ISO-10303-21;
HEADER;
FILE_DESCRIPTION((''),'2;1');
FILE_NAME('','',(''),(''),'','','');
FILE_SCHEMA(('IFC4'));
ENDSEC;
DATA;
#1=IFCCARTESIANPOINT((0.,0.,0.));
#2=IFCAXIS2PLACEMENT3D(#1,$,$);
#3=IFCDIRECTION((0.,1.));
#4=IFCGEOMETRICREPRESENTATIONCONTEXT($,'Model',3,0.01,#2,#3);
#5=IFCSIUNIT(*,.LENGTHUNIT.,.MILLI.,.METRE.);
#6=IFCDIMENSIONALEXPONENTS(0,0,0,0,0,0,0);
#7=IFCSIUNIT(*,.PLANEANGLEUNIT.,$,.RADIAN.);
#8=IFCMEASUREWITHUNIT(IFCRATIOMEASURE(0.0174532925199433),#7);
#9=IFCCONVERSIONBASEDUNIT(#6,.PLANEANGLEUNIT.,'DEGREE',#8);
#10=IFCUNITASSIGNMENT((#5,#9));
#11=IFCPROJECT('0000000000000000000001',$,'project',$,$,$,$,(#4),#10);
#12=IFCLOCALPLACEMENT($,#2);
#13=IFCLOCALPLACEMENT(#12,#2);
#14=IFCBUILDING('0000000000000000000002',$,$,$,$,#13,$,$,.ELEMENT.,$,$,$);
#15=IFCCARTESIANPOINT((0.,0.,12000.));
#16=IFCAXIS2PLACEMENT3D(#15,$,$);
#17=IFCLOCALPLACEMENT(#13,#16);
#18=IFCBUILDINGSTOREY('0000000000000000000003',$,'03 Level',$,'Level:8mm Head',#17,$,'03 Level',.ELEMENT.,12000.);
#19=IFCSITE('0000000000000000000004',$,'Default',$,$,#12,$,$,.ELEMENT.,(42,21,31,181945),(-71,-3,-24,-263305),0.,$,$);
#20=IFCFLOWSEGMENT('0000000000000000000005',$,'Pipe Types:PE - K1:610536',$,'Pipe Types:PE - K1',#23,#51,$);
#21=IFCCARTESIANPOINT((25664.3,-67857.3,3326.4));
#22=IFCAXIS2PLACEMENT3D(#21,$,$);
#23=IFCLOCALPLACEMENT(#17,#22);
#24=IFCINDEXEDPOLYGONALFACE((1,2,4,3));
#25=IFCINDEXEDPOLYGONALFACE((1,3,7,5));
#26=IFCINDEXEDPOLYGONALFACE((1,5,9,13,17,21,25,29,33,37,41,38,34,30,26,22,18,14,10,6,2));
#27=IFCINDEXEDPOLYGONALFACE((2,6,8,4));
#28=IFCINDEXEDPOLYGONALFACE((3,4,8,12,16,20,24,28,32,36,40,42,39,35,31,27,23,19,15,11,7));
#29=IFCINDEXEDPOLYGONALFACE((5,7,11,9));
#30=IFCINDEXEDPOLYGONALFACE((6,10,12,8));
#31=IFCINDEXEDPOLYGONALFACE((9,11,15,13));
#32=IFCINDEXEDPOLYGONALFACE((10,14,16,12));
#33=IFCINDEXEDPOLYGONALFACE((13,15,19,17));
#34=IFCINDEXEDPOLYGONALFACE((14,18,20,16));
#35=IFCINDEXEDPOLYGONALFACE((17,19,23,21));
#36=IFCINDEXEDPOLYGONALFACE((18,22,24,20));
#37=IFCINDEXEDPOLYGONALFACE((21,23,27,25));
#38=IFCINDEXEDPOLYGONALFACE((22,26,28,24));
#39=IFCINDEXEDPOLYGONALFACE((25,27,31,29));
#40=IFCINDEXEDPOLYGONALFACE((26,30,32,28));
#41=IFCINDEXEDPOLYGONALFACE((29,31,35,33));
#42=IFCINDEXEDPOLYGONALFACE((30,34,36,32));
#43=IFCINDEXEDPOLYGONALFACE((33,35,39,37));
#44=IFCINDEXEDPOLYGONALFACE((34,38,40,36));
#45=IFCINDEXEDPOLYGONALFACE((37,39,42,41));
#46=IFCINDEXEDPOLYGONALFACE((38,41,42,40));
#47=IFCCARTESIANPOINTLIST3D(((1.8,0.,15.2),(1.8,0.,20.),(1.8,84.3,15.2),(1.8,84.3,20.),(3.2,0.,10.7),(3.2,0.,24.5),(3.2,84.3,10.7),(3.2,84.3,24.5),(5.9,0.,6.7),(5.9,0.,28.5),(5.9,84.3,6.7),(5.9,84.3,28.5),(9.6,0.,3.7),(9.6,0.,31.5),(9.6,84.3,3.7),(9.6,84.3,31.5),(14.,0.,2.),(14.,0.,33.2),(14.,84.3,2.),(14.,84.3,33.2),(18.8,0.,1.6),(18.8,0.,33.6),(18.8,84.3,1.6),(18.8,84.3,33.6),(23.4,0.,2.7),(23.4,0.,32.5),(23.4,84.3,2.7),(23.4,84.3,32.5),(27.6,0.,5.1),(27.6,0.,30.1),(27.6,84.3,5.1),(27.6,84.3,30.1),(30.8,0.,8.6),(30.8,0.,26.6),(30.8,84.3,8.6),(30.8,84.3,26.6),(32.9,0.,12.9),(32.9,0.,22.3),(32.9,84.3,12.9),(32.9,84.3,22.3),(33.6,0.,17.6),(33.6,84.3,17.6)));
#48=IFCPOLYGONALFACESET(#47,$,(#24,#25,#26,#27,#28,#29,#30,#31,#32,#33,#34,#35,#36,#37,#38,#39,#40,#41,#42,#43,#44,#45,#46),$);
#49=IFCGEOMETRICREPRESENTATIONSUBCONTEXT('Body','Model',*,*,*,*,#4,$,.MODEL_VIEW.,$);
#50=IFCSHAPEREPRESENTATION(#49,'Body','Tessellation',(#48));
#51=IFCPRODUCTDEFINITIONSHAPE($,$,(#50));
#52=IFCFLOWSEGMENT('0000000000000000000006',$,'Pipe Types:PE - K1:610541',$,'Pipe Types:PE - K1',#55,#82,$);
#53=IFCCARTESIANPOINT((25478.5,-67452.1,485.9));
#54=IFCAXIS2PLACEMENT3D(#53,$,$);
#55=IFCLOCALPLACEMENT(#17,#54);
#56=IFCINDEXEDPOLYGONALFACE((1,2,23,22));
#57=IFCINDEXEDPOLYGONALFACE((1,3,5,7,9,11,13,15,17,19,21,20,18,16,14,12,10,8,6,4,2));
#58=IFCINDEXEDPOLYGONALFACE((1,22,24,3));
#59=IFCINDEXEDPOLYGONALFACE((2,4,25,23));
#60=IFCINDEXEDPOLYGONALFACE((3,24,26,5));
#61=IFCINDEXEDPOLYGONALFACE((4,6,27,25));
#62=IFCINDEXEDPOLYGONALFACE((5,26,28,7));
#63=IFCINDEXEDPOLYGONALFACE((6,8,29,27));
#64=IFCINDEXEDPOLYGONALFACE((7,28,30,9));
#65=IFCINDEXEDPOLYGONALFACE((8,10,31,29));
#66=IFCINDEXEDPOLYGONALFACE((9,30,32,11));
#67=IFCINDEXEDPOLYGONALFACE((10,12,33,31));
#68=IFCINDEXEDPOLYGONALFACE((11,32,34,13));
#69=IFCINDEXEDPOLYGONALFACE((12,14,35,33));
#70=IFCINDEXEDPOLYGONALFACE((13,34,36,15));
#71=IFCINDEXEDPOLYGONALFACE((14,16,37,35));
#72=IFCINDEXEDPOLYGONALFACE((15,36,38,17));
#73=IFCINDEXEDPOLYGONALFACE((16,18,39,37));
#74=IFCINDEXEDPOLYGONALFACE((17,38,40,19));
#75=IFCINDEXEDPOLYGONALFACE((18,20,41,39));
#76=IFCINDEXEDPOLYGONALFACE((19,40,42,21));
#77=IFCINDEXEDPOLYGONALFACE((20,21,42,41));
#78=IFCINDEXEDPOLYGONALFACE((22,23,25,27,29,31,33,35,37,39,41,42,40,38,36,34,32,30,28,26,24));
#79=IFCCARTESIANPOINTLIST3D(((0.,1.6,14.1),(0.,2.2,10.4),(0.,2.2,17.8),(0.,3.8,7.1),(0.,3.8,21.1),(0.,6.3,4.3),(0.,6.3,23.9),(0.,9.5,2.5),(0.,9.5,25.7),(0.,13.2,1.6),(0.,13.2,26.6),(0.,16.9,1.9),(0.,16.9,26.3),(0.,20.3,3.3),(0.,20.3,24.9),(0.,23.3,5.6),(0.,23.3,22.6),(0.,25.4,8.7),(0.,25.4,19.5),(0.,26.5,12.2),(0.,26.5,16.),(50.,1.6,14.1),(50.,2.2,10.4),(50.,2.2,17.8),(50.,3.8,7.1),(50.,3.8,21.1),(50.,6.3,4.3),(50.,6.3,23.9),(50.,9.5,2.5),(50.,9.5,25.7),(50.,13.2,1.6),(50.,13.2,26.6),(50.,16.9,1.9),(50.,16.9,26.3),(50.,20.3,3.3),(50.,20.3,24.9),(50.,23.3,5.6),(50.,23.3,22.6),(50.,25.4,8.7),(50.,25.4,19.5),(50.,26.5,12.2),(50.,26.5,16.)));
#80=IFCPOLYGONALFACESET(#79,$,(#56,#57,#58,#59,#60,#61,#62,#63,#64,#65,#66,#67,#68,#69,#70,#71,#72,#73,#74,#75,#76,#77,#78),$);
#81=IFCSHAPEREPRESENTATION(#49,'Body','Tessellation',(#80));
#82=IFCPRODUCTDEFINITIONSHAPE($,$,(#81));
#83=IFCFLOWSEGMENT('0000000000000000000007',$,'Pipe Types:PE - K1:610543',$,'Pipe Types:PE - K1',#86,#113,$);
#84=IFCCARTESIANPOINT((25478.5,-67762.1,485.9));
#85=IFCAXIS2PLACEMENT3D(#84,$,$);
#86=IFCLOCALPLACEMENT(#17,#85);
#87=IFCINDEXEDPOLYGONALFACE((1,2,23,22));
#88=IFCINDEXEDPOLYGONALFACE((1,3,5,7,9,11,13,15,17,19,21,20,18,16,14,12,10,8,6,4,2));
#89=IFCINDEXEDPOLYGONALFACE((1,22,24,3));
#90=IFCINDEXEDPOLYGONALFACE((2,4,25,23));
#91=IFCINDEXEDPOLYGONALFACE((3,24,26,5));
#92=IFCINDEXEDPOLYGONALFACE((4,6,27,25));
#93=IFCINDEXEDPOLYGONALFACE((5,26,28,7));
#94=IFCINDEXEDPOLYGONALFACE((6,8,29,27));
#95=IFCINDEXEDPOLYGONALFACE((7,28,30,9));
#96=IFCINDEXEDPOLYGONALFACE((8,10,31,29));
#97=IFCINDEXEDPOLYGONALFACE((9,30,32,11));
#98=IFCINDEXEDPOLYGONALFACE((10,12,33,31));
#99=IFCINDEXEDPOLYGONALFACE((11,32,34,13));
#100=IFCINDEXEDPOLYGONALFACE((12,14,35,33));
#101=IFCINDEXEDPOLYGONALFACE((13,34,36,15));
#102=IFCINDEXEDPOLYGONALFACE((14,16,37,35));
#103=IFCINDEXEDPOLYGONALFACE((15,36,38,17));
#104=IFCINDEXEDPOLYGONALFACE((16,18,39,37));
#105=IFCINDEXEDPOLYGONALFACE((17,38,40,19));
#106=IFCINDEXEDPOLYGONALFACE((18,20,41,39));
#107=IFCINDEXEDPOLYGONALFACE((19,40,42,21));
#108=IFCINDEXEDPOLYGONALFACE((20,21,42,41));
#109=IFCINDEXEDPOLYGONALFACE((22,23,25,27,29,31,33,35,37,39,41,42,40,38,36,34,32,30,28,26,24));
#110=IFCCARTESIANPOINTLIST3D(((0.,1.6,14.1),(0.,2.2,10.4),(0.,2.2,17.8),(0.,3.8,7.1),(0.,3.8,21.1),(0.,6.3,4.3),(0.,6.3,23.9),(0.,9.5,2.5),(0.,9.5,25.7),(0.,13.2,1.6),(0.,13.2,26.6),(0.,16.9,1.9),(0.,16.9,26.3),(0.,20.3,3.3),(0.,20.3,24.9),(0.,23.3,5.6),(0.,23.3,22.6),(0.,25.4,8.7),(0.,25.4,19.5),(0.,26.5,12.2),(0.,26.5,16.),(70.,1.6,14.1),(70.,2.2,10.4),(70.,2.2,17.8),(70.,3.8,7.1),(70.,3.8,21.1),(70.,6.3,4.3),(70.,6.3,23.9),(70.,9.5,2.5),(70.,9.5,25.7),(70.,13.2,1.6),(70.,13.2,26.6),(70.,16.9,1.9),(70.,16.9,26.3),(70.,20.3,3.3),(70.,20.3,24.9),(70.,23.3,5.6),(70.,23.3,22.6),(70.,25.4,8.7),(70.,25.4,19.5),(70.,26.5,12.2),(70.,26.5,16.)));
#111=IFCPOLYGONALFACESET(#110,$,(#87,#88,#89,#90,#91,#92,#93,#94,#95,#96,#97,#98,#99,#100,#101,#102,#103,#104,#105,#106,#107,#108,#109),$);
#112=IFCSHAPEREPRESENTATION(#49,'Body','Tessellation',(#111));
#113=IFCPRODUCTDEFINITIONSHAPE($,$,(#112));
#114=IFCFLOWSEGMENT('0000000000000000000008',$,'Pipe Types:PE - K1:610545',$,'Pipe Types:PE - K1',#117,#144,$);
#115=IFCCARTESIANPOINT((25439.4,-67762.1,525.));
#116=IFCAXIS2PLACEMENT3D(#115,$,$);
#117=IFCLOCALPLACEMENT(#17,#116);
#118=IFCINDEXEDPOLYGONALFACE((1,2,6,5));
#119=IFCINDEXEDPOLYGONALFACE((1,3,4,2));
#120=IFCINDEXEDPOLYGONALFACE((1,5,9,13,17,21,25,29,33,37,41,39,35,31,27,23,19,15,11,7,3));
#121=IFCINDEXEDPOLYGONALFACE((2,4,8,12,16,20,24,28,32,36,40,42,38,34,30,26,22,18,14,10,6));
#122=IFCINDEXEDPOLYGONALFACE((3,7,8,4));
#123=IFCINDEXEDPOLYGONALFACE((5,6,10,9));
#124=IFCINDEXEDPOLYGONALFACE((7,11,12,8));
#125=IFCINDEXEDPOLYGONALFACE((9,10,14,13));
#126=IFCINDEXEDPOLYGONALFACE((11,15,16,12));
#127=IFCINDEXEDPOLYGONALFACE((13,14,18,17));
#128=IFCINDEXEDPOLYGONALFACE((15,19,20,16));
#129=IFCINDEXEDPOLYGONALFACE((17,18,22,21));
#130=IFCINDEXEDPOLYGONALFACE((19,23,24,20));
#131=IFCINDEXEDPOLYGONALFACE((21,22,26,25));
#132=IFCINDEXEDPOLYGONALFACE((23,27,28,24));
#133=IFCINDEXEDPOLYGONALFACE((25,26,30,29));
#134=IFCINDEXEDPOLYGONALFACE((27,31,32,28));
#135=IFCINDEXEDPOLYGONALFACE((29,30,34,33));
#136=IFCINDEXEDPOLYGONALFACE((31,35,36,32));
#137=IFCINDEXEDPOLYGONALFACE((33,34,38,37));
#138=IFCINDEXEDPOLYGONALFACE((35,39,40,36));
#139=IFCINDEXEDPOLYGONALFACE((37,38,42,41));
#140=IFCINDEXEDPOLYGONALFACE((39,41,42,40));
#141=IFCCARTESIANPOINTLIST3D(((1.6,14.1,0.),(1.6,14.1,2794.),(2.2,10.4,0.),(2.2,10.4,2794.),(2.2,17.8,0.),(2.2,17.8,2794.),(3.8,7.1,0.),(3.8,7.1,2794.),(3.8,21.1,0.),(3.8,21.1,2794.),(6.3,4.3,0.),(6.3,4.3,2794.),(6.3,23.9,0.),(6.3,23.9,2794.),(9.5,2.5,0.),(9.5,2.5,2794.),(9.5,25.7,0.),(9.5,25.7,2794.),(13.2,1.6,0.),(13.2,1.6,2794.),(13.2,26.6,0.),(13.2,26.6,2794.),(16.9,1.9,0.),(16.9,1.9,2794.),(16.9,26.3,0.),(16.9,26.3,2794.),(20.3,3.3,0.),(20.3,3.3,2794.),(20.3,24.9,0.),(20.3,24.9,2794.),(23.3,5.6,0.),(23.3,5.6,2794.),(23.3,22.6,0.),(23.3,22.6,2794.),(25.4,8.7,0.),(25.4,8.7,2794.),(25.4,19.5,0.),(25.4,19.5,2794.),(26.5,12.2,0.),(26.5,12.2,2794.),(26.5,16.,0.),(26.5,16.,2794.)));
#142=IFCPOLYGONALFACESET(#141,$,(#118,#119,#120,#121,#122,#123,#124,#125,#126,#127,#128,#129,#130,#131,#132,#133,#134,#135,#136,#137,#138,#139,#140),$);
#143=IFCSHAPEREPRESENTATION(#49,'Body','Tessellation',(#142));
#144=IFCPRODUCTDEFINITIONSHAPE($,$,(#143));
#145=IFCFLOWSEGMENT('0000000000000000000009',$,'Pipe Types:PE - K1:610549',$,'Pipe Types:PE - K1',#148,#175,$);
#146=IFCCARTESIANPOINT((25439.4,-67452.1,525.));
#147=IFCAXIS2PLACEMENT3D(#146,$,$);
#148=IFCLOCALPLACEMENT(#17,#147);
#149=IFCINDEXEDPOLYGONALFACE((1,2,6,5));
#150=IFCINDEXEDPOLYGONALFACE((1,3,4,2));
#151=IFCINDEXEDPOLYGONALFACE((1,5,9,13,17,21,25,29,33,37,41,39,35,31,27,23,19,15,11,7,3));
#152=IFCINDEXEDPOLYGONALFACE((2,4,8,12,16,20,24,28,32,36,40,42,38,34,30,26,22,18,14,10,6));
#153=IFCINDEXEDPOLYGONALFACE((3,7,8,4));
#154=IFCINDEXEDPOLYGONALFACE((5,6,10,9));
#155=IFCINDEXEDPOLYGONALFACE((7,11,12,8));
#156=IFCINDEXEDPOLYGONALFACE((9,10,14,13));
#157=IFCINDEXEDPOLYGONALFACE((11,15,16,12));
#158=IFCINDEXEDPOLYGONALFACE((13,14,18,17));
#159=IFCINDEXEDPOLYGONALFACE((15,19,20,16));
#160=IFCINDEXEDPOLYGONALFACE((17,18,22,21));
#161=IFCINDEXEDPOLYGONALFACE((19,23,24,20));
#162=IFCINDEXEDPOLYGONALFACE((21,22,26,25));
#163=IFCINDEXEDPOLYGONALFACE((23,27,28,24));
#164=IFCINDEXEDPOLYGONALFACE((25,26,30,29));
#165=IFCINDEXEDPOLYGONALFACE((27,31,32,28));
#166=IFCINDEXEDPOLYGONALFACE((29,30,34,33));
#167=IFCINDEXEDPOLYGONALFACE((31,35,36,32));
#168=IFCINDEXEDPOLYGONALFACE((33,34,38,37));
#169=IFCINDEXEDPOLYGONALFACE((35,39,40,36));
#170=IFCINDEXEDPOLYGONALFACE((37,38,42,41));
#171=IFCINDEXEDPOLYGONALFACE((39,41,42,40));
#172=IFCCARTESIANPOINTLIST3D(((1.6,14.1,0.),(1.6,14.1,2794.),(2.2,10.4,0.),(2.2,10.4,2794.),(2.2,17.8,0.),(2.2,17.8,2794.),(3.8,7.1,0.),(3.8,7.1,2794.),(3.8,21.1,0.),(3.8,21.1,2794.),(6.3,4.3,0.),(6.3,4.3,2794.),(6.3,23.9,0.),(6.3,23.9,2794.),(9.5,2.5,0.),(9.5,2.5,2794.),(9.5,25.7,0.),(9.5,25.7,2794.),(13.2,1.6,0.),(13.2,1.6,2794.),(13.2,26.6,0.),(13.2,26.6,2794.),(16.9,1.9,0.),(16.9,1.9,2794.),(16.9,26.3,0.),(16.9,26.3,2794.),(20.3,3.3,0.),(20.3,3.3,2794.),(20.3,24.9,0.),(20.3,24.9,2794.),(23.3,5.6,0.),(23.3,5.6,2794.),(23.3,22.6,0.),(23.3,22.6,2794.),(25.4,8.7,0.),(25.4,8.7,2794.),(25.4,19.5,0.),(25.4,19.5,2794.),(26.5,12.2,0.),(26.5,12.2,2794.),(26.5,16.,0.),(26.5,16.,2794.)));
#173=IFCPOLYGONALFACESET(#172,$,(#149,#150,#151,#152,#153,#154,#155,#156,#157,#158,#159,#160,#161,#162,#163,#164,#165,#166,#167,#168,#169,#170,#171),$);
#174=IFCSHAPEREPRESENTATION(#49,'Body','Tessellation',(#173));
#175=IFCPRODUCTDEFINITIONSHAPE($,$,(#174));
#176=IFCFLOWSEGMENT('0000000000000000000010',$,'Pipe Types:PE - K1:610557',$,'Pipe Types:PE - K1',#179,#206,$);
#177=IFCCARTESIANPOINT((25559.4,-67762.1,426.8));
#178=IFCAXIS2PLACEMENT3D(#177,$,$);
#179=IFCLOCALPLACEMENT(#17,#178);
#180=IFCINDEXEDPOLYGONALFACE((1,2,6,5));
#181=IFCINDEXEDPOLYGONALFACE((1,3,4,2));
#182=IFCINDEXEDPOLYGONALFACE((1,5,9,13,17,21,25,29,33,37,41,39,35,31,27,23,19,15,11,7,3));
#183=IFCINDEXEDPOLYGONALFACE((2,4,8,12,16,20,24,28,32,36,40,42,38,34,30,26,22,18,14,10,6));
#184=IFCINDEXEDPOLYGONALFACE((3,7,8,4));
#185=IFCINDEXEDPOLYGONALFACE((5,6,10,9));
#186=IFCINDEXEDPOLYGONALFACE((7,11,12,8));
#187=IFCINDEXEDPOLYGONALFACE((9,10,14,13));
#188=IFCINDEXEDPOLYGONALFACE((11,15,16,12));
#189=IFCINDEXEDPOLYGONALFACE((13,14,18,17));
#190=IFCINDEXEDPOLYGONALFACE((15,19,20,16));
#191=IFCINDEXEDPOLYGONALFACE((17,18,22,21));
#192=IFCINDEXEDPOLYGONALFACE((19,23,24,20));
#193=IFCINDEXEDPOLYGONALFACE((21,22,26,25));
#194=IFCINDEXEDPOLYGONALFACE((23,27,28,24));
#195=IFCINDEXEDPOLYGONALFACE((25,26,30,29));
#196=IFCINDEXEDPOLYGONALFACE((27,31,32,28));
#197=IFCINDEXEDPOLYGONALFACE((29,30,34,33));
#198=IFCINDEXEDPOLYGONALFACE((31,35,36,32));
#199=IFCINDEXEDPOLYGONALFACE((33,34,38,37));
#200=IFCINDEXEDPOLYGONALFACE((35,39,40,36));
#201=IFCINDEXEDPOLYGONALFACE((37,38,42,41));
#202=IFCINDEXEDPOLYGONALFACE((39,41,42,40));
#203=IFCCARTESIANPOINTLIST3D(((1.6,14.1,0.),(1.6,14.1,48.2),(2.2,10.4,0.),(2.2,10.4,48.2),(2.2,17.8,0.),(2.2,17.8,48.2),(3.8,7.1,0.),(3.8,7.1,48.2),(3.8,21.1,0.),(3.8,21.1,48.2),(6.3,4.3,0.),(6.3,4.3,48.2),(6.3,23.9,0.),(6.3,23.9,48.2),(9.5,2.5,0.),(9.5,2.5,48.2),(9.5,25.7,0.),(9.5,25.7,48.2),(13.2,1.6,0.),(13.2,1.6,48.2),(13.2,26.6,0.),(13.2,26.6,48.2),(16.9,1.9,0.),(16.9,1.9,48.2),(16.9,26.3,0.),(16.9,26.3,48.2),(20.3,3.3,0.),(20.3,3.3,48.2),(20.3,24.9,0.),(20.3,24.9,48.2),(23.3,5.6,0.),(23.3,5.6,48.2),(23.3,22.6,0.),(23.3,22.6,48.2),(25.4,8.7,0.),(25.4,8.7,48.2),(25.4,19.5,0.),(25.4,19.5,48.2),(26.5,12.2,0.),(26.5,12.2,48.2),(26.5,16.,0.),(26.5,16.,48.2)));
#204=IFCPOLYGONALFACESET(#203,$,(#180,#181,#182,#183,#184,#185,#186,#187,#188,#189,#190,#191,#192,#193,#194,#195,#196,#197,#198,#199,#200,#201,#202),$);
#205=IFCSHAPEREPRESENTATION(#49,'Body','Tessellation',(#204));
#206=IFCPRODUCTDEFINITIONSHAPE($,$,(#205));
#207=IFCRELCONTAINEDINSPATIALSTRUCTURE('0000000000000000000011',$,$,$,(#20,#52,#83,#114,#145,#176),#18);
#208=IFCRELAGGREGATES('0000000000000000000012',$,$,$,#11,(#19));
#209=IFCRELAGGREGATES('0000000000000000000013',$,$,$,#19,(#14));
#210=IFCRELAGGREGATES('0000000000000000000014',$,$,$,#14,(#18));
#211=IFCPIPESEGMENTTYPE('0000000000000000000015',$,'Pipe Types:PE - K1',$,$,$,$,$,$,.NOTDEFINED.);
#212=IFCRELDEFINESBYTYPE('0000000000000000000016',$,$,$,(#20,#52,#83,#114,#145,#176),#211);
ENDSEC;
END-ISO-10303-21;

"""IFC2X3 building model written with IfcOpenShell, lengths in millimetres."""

from ifc_helpers import new_model, entity, si_unit, converted_unit, direction, frame, origin, origin_2d_with_axis, place, context, subcontext, project, spatial, circle, extrude, type_object, element, save


model = new_model("IFC2X3")

# Units and contexts
model_context = context("Model", 3, precision=0.01, world=origin(), true_north=direction((0.0, 1.0)))
body_context = subcontext(model_context, "Body", "Model", "MODEL_VIEW")
ifc_project = project(units=[si_unit("LENGTHUNIT", "METRE", prefix="MILLI"), converted_unit("PLANEANGLEUNIT", "DEGREE", entity("IfcRatioMeasure", 0.0174532925199433), si_unit("PLANEANGLEUNIT", "RADIAN"), dimensions=[0, 0, 0, 0, 0, 0, 0])], contexts=[model_context])

# Site, building, storey
site_placement = place(None, origin())
site = spatial("IfcSite", under=ifc_project, at=site_placement, Name="Default", CompositionType="ELEMENT", RefLatitude=(42, 21, 31, 181945), RefLongitude=(-71, -3, -24, -263305), RefElevation=0.0)
building_placement = place(site_placement, origin())
building = spatial("IfcBuilding", under=site, at=building_placement, CompositionType="ELEMENT")
storey_placement = place(building_placement, frame((0.0, 0.0, 12000.0)))
storey = spatial("IfcBuildingStorey", under=building, at=storey_placement, Name="03 Level", ObjectType="Level:8mm Head", LongName="03 Level", CompositionType="ELEMENT", Elevation=12000.0)

# Flow segments
pipe_segment_type = type_object("IfcPipeSegmentType", Name="Pipe Types:PE - K1", PredefinedType="NOTDEFINED")
flow_segment_1_placement = place(storey_placement, frame((25664.3, -67857.3, 3326.4)))
element("IfcFlowSegment", 1, at=flow_segment_1_placement, inside=storey, type_object=pipe_segment_type, Name="Pipe Types:PE - K1:610536", ObjectType="Pipe Types:PE - K1", context=body_context, shape_type="SweptSolid", body=[
    extrude(circle(Radius=16.0, at=origin_2d_with_axis()), frame((17.6, 0.0, 17.6), z_axis=(0.0, 1.0, 0.0), x_axis=(1.0, 0.0, 0.0)), (0.0, 0.0, 1.0), 84.3),
])
flow_segment_2_placement = place(storey_placement, frame((25478.5, -67452.1, 485.9)))
element("IfcFlowSegment", 2, at=flow_segment_2_placement, inside=storey, type_object=pipe_segment_type, Name="Pipe Types:PE - K1:610541", ObjectType="Pipe Types:PE - K1", context=body_context, shape_type="SweptSolid", body=[
    extrude(circle(Radius=12.5, at=origin_2d_with_axis()), frame((0.0, 14.1, 14.1), z_axis=(1.0, 0.0, 0.0), x_axis=(0.0, -1.0, 0.0)), (0.0, 0.0, 1.0), 50.0),
])
flow_segment_3_placement = place(storey_placement, frame((25478.5, -67762.1, 485.9)))
element("IfcFlowSegment", 3, at=flow_segment_3_placement, inside=storey, type_object=pipe_segment_type, Name="Pipe Types:PE - K1:610543", ObjectType="Pipe Types:PE - K1", context=body_context, shape_type="SweptSolid", body=[
    extrude(circle(Radius=12.5, at=origin_2d_with_axis()), frame((0.0, 14.1, 14.1), z_axis=(1.0, 0.0, 0.0), x_axis=(0.0, -1.0, 0.0)), (0.0, 0.0, 1.0), 70.0),
])
flow_segment_4_placement = place(storey_placement, frame((25439.4, -67762.1, 525.0)))
element("IfcFlowSegment", 4, at=flow_segment_4_placement, inside=storey, type_object=pipe_segment_type, Name="Pipe Types:PE - K1:610545", ObjectType="Pipe Types:PE - K1", context=body_context, shape_type="SweptSolid", body=[
    extrude(circle(Radius=12.5, at=origin_2d_with_axis()), frame((14.1, 14.1, 0.0), z_axis=(0.0, 0.0, 1.0), x_axis=(-1.0, 0.0, 0.0)), (0.0, 0.0, 1.0), 2794.0),
])
flow_segment_5_placement = place(storey_placement, frame((25439.4, -67452.1, 525.0)))
element("IfcFlowSegment", 5, at=flow_segment_5_placement, inside=storey, type_object=pipe_segment_type, Name="Pipe Types:PE - K1:610549", ObjectType="Pipe Types:PE - K1", context=body_context, shape_type="SweptSolid", body=[
    extrude(circle(Radius=12.5, at=origin_2d_with_axis()), frame((14.1, 14.1, 0.0), z_axis=(0.0, 0.0, 1.0), x_axis=(-1.0, 0.0, 0.0)), (0.0, 0.0, 1.0), 2794.0),
])
flow_segment_6_placement = place(storey_placement, frame((25559.4, -67762.1, 426.8)))
element("IfcFlowSegment", 6, at=flow_segment_6_placement, inside=storey, type_object=pipe_segment_type, Name="Pipe Types:PE - K1:610557", ObjectType="Pipe Types:PE - K1", context=body_context, shape_type="SweptSolid", body=[
    extrude(circle(Radius=12.5, at=origin_2d_with_axis()), frame((14.1, 14.1, 0.0), z_axis=(0.0, 0.0, 1.0), x_axis=(-1.0, 0.0, 0.0)), (0.0, 0.0, 1.0), 48.2),
])

save(model, "model.ifc")
